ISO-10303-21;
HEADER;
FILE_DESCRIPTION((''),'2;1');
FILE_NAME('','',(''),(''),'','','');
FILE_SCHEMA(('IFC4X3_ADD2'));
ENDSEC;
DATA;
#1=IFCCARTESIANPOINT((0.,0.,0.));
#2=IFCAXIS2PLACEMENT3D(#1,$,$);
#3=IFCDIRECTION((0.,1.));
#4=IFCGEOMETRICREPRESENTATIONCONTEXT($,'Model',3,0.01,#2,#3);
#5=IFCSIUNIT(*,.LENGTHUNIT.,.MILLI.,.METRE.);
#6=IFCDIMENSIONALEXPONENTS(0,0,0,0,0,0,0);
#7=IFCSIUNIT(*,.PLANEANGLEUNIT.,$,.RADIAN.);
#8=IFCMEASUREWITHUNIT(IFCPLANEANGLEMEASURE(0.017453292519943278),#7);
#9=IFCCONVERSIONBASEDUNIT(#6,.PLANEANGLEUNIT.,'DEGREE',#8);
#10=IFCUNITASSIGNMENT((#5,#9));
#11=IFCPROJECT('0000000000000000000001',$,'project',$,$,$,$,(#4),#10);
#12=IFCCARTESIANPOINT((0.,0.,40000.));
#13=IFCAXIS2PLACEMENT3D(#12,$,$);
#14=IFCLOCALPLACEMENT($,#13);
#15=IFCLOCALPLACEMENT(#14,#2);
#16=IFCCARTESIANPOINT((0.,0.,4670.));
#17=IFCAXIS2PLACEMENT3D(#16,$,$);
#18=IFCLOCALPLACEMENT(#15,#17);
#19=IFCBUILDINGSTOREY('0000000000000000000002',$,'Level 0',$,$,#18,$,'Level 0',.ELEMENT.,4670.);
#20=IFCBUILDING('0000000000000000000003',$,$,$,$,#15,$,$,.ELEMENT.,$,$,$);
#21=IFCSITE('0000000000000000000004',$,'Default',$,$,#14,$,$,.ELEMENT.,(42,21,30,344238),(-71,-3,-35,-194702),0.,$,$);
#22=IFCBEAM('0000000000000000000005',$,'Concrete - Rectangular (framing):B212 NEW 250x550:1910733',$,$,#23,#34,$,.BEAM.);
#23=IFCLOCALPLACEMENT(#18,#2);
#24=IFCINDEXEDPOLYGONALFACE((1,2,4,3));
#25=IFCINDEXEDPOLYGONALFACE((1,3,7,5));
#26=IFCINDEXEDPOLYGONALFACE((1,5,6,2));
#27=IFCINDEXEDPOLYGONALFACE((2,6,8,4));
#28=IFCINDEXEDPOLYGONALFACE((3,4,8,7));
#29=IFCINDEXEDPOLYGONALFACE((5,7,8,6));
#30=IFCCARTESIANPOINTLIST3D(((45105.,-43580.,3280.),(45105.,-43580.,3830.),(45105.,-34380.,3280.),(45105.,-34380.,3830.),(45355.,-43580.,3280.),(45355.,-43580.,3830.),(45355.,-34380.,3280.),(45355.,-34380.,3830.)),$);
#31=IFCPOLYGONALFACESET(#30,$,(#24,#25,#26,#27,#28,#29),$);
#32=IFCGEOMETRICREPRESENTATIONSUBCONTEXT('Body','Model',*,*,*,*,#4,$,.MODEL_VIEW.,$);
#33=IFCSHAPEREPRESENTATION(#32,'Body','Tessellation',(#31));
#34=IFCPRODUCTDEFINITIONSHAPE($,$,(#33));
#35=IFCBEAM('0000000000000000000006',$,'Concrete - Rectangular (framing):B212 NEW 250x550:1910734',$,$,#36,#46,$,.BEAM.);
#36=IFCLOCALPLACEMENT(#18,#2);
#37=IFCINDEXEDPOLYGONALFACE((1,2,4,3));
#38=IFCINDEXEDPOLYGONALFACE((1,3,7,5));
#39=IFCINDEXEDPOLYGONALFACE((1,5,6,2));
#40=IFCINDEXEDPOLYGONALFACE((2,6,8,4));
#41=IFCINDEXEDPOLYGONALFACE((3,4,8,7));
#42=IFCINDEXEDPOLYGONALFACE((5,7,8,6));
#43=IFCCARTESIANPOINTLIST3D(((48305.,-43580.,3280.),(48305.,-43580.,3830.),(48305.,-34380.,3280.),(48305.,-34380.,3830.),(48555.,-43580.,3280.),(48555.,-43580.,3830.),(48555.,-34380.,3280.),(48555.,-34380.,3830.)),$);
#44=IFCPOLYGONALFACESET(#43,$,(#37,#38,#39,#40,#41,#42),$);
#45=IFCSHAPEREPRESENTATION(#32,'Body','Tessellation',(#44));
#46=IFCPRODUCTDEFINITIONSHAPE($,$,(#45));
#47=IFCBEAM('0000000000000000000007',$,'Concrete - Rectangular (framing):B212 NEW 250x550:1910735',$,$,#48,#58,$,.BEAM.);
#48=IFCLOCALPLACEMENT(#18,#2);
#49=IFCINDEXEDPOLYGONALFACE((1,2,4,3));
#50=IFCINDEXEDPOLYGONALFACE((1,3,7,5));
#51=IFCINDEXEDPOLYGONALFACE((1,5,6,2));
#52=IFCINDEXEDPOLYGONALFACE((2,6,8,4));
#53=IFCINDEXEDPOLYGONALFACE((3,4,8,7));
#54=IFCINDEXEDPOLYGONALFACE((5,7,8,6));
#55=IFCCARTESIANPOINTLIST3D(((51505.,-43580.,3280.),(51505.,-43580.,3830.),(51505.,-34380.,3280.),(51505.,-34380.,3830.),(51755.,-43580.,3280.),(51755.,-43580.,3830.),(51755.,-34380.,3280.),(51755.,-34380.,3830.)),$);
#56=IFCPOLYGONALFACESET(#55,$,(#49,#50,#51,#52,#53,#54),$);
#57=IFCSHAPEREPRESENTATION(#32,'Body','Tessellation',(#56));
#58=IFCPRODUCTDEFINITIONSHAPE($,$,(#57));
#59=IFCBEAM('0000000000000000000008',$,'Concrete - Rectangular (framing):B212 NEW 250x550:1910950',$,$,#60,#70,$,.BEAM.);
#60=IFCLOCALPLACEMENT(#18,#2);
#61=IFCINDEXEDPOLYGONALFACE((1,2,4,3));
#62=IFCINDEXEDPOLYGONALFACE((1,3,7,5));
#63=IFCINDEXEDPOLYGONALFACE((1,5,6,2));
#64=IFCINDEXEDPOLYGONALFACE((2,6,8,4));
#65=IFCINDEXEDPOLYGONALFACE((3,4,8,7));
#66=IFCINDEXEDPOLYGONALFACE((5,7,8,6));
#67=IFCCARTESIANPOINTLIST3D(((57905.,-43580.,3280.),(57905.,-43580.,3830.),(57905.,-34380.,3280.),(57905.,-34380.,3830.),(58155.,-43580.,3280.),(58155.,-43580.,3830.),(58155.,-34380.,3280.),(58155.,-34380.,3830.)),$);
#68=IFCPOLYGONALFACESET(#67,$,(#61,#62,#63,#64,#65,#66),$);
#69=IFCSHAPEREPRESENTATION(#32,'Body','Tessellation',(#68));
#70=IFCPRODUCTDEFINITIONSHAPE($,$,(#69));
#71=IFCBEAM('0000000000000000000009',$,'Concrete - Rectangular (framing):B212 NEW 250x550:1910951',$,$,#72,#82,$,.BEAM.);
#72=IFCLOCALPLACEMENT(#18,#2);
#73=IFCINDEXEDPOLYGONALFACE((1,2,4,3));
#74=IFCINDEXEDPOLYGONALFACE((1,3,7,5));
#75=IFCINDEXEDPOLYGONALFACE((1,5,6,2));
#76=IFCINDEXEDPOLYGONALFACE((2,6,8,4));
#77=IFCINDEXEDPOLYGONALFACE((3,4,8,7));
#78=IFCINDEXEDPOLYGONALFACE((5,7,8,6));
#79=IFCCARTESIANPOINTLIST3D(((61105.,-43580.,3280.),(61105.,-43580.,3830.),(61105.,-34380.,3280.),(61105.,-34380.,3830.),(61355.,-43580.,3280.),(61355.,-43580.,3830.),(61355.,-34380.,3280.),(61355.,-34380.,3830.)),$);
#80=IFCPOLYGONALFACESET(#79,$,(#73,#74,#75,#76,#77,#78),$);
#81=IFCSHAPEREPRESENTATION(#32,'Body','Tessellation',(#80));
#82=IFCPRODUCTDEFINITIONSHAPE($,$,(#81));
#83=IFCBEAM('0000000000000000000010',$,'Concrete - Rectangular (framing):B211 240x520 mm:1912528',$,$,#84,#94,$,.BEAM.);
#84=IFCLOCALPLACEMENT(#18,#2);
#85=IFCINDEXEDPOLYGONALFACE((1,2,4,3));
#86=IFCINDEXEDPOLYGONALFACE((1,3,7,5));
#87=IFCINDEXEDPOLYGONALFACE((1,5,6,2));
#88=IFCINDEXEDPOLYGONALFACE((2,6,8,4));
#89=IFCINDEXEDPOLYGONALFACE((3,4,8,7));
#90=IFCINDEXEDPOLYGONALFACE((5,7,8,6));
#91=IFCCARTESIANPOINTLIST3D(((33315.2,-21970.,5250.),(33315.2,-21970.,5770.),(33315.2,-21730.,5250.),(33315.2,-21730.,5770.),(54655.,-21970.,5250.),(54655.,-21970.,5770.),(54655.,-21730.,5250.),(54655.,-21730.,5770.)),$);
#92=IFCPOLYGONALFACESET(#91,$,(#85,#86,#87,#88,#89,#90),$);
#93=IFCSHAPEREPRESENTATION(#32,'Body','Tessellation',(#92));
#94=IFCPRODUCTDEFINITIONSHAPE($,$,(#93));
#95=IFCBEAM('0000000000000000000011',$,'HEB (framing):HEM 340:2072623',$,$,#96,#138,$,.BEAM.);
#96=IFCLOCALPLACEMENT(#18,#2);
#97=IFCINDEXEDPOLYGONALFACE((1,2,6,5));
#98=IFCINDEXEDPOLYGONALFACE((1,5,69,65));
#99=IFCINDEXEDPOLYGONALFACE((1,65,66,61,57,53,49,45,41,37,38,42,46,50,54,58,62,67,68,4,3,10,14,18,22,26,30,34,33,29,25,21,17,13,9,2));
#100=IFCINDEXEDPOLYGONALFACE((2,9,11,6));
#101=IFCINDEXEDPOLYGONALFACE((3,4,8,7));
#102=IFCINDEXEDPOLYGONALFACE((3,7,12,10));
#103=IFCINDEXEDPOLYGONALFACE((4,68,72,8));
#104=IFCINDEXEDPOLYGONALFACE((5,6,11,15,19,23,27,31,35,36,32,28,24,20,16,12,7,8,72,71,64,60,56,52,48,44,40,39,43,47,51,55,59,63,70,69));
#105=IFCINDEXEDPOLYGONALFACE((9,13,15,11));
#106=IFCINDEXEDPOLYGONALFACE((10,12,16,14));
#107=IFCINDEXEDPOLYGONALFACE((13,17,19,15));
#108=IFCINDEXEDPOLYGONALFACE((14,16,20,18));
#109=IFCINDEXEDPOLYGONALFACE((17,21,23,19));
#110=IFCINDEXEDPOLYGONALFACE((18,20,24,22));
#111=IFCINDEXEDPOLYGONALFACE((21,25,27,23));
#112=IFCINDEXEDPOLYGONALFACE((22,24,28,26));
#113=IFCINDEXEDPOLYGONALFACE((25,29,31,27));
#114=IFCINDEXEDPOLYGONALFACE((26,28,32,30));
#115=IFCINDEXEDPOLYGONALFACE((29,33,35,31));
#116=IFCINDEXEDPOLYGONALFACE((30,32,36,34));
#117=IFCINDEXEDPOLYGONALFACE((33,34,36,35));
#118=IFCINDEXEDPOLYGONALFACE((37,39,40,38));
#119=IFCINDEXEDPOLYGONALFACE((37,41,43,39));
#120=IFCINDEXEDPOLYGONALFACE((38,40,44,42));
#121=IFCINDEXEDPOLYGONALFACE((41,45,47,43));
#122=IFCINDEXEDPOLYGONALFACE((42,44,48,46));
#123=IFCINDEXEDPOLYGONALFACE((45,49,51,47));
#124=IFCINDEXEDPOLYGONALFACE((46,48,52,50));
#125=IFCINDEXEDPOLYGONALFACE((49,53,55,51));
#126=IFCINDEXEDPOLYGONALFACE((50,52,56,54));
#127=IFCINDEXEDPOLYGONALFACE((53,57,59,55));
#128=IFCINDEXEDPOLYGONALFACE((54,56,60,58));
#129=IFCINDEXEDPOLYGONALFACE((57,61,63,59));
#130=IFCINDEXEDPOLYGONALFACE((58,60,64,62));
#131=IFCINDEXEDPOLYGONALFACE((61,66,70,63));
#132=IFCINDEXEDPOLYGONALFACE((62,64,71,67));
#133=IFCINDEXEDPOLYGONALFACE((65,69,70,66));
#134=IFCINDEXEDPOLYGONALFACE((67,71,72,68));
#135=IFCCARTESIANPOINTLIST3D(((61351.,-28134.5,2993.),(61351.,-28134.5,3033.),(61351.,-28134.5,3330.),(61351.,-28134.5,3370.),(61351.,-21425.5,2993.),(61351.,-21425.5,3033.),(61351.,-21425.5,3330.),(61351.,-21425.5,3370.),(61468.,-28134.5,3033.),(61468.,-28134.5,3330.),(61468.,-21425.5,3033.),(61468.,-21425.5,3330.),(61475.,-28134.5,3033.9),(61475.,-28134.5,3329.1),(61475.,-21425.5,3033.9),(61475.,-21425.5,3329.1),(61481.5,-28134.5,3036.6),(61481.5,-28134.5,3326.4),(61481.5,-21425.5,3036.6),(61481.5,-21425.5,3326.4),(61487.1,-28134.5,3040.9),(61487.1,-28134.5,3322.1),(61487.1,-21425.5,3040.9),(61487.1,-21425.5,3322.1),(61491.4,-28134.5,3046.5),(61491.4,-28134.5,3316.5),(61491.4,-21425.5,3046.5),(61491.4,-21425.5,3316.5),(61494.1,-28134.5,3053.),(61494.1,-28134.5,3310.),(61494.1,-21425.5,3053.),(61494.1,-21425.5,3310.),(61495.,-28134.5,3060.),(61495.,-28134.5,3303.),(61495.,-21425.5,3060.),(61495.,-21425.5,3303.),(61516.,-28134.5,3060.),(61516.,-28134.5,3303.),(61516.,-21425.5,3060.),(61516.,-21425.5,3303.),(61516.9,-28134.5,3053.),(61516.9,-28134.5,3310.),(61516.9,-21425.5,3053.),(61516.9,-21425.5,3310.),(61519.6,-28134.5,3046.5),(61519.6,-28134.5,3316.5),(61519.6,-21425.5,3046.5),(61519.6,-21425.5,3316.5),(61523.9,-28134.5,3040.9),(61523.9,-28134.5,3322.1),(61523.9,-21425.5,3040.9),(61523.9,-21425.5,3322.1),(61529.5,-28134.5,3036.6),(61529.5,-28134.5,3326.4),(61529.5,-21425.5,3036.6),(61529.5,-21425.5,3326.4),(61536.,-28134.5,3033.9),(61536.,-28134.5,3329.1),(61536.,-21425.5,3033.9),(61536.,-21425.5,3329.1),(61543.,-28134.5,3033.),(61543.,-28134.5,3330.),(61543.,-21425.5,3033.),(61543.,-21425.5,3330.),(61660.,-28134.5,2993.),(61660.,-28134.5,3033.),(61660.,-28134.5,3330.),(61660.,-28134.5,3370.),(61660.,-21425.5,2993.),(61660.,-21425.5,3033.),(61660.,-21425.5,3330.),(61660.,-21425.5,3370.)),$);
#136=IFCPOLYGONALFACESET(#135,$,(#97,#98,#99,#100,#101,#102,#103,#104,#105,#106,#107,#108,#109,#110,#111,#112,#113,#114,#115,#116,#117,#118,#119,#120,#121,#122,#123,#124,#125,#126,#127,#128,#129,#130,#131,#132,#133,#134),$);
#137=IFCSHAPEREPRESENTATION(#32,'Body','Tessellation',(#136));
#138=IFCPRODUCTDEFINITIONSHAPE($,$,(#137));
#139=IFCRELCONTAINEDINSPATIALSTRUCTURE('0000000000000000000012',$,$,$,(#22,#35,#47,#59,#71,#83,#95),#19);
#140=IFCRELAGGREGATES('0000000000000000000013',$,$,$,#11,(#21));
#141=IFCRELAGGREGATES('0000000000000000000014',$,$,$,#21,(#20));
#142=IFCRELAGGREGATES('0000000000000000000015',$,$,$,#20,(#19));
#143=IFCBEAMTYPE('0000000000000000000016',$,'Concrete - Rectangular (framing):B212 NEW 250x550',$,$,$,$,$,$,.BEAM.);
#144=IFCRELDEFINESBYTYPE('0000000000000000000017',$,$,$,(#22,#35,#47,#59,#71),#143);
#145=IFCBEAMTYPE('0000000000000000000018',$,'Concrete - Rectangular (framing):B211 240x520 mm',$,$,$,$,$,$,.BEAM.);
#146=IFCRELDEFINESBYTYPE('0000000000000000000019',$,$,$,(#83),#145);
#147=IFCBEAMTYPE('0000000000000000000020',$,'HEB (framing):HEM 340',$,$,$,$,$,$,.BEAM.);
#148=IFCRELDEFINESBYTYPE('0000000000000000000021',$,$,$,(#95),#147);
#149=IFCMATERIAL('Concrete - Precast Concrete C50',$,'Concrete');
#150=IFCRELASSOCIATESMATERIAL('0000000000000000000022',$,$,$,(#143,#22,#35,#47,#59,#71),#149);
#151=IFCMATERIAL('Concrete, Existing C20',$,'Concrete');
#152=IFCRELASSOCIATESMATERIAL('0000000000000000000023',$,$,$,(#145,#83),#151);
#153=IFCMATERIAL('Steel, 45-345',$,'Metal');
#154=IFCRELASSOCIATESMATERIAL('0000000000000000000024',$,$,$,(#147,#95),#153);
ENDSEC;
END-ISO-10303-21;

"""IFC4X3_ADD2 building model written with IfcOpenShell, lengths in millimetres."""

from ifc_helpers import new_model, entity, si_unit, converted_unit, direction, frame, frame_2d, origin, origin_2d_with_axis, place, context, subcontext, project, spatial, polyline, circle_curve, parameter, trimmed, segment, composite_curve, rectangle, outline, extrude, source, transform, mapped, material, material_profile, profile_set, profile_usage, type_object, type_shapes, element, save


model = new_model("IFC4X3_ADD2")

# Units and contexts
model_context = context("Model", 3, precision=0.01, world=origin(), true_north=direction((0.0, 1.0)))
body_context = subcontext(model_context, "Body", "Model", "MODEL_VIEW")
ifc_project = project(units=[si_unit("LENGTHUNIT", "METRE", prefix="MILLI"), converted_unit("PLANEANGLEUNIT", "DEGREE", entity("IfcPlaneAngleMeasure", 0.017453292519943278), si_unit("PLANEANGLEUNIT", "RADIAN"), dimensions=[0, 0, 0, 0, 0, 0, 0])], contexts=[model_context])

# Site, building, storey
site_placement = place(None, frame((0.0, 0.0, 40000.0)))
site = spatial("IfcSite", under=ifc_project, at=site_placement, Name="Default", CompositionType="ELEMENT", RefLatitude=(42, 21, 30, 344238), RefLongitude=(-71, -3, -35, -194702), RefElevation=0.0)
building_placement = place(site_placement, origin())
building = spatial("IfcBuilding", under=site, at=building_placement, CompositionType="ELEMENT")
storey_placement = place(building_placement, frame((0.0, 0.0, 4670.0)))
storey = spatial("IfcBuildingStorey", under=building, at=storey_placement, Name="Level 0", LongName="Level 0", CompositionType="ELEMENT", Elevation=4670.0)

# Shared definitions
ifc_material_1 = material(Name="Steel, 45-345", Category="Metal")

# Beams
ifc_material_profile_1 = material_profile(ifc_material_1, outline(composite_curve([segment(polyline([(-154.5, -148.5), (-154.5, -188.5)]), True, "CONTINUOUS"), segment(polyline([(-154.5, -188.5), (154.5, -188.5)]), True, "CONTINUOUS"), segment(polyline([(154.5, -188.5), (154.5, -148.5)]), True, "CONTINUOUS"), segment(polyline([(154.5, -148.5), (37.5, -148.5)]), True, "CONTINUOUS"), segment(trimmed(circle_curve(frame_2d((37.5, -121.5), x_axis=(1.0, 0.0)), 27.0), [parameter(180.0)], [parameter(270.0)], True, "PARAMETER"), False, "CONTINUOUS"), segment(polyline([(10.5, -121.5), (10.5, 121.5)]), True, "CONTINUOUS"), segment(trimmed(circle_curve(frame_2d((37.5, 121.5), x_axis=(1.0, 0.0)), 27.0), [parameter(90.0)], [parameter(180.0)], True, "PARAMETER"), False, "CONTINUOUS"), segment(polyline([(37.5, 148.5), (154.5, 148.5)]), True, "CONTINUOUS"), segment(polyline([(154.5, 148.5), (154.5, 188.5)]), True, "CONTINUOUS"), segment(polyline([(154.5, 188.5), (-154.5, 188.5)]), True, "CONTINUOUS"), segment(polyline([(-154.5, 188.5), (-154.5, 148.5)]), True, "CONTINUOUS"), segment(polyline([(-154.5, 148.5), (-37.5, 148.5)]), True, "CONTINUOUS"), segment(trimmed(circle_curve(frame_2d((-37.5, 121.5), x_axis=(1.0, 0.0)), 27.0), [parameter(360.0)], [parameter(90.0)], True, "PARAMETER"), False, "CONTINUOUS"), segment(polyline([(-10.5, 121.5), (-10.5, -121.5)]), True, "CONTINUOUS"), segment(trimmed(circle_curve(frame_2d((-37.5, -121.5), x_axis=(1.0, 0.0)), 27.0), [parameter(270.0)], [parameter(0.0)], True, "PARAMETER"), False, "CONTINUOUS"), segment(polyline([(-37.5, -148.5), (-154.5, -148.5)]), True, "CONTINUOUS")], self_intersect=False)), Name="HEM 340")
ifc_profile_set_1 = profile_set([ifc_material_profile_1], Name="HEM 340")
ifc_profile_usage_1 = profile_usage(ifc_profile_set_1, cardinal=8)
ifc_material_2 = material(Name="Concrete - Precast Concrete C50", Category="Concrete")
ifc_material_profile_2 = material_profile(ifc_material_2, rectangle(XDim=9200.0, YDim=250.0, at=origin_2d_with_axis()), Name="B212 NEW 250x550")
ifc_profile_set_2 = profile_set([ifc_material_profile_2], Name="B212 NEW 250x550")
ifc_profile_usage_2 = profile_usage(ifc_profile_set_2, cardinal=8)
beam_type_1 = type_object("IfcBeamType", Name="Concrete - Rectangular (framing):B212 NEW 250x550", PredefinedType="BEAM", material=ifc_profile_set_2)
shared_shape_1 = source(origin(), body_context, "Body", "SweptSolid", [
    extrude(rectangle(XDim=9200.0, YDim=250.0, at=origin_2d_with_axis()), frame((0.0, 0.0, -275.0), z_axis=(0.0, 0.0, 1.0), x_axis=(-1.0, 0.0, 0.0)), (0.0, 0.0, 1.0), 550.0),
])
type_shapes(beam_type_1, [shared_shape_1])
for number, where, z_axis, x_axis, name in (
    (1, (45230.0, -38980.0, 3555.0), (0.0, 0.0, 1.0), (0.0, 1.0, 0.0), "Concrete - Rectangular (framing):B212 NEW 250x550:1910733"),
    (2, (48430.0, -38980.0, 3555.0), (0.0, 0.0, 1.0), (0.0, 1.0, 0.0), "Concrete - Rectangular (framing):B212 NEW 250x550:1910734"),
    (3, (51630.0, -38980.0, 3555.0), (0.0, 0.0, 1.0), (0.0, 1.0, 0.0), "Concrete - Rectangular (framing):B212 NEW 250x550:1910735"),
    (4, (58030.0, -38980.0, 3555.0), (0.0, 0.0, 1.0), (0.0, 1.0, 0.0), "Concrete - Rectangular (framing):B212 NEW 250x550:1910950"),
    (5, (61230.0, -38980.0, 3555.0), (0.0, 0.0, 1.0), (0.0, 1.0, 0.0), "Concrete - Rectangular (framing):B212 NEW 250x550:1910951"),
):
    element("IfcBeam", number, at=place(storey_placement, frame(where, z_axis=z_axis, x_axis=x_axis)), inside=storey, type_object=beam_type_1, material=ifc_profile_usage_2, Name=name, PredefinedType="BEAM", context=body_context, shape_type="MappedRepresentation", body=[
        mapped(shared_shape_1, transform((0.0, 0.0, 0.0), scale=1.0)),
    ])
ifc_material_3 = material(Name="Concrete, Existing C20", Category="Concrete")
ifc_material_profile_3 = material_profile(ifc_material_3, rectangle(XDim=21339.8, YDim=240.0, at=origin_2d_with_axis()), Name="B211 240x520 mm")
ifc_profile_set_3 = profile_set([ifc_material_profile_3], Name="B211 240x520 mm")
ifc_profile_usage_3 = profile_usage(ifc_profile_set_3, cardinal=8)
beam_type_2 = type_object("IfcBeamType", Name="Concrete - Rectangular (framing):B211 240x520 mm", PredefinedType="BEAM", material=ifc_profile_set_3)
shared_shape_2 = source(origin(), body_context, "Body", "SweptSolid", [
    extrude(rectangle(XDim=21339.8, YDim=240.0, at=origin_2d_with_axis()), frame((-60.1, 0.0, -260.0), z_axis=(0.0, 0.0, 1.0), x_axis=(-1.0, 0.0, 0.0)), (0.0, 0.0, 1.0), 520.0),
])
type_shapes(beam_type_2, [shared_shape_2])
beam_1_placement = place(storey_placement, frame((43925.0, -21850.0, 5510.0), z_axis=(0.0, 0.0, 1.0), x_axis=(-1.0, 0.0, 0.0)))
element("IfcBeam", 6, at=beam_1_placement, inside=storey, type_object=beam_type_2, material=ifc_profile_usage_3, Name="Concrete - Rectangular (framing):B211 240x520 mm:1912528", PredefinedType="BEAM", context=body_context, shape_type="MappedRepresentation", body=[
    mapped(shared_shape_2, transform((0.0, 0.0, 0.0), scale=1.0)),
])
beam_type_3 = type_object("IfcBeamType", Name="HEB (framing):HEM 340", PredefinedType="BEAM", material=ifc_profile_set_1)
shared_shape_3 = source(origin(), body_context, "Body", "SweptSolid", [
    extrude(outline(composite_curve([segment(polyline([(-154.5, -148.5), (-154.5, -188.5)]), True, "CONTINUOUS"), segment(polyline([(-154.5, -188.5), (154.5, -188.5)]), True, "CONTINUOUS"), segment(polyline([(154.5, -188.5), (154.5, -148.5)]), True, "CONTINUOUS"), segment(polyline([(154.5, -148.5), (37.5, -148.5)]), True, "CONTINUOUS"), segment(trimmed(circle_curve(frame_2d((37.5, -121.5), x_axis=(1.0, 0.0)), 27.0), [parameter(180.0)], [parameter(270.0)], True, "PARAMETER"), False, "CONTINUOUS"), segment(polyline([(10.5, -121.5), (10.5, 121.5)]), True, "CONTINUOUS"), segment(trimmed(circle_curve(frame_2d((37.5, 121.5), x_axis=(1.0, 0.0)), 27.0), [parameter(90.0)], [parameter(180.0)], True, "PARAMETER"), False, "CONTINUOUS"), segment(polyline([(37.5, 148.5), (154.5, 148.5)]), True, "CONTINUOUS"), segment(polyline([(154.5, 148.5), (154.5, 188.5)]), True, "CONTINUOUS"), segment(polyline([(154.5, 188.5), (-154.5, 188.5)]), True, "CONTINUOUS"), segment(polyline([(-154.5, 188.5), (-154.5, 148.5)]), True, "CONTINUOUS"), segment(polyline([(-154.5, 148.5), (-37.5, 148.5)]), True, "CONTINUOUS"), segment(trimmed(circle_curve(frame_2d((-37.5, 121.5), x_axis=(1.0, 0.0)), 27.0), [parameter(360.0)], [parameter(90.0)], True, "PARAMETER"), False, "CONTINUOUS"), segment(polyline([(-10.5, 121.5), (-10.5, -121.5)]), True, "CONTINUOUS"), segment(trimmed(circle_curve(frame_2d((-37.5, -121.5), x_axis=(1.0, 0.0)), 27.0), [parameter(270.0)], [parameter(0.0)], True, "PARAMETER"), False, "CONTINUOUS"), segment(polyline([(-37.5, -148.5), (-154.5, -148.5)]), True, "CONTINUOUS")], self_intersect=False)), frame((-3354.5, 0.0, 0.0), z_axis=(-1.0, 0.0, 0.0), x_axis=(0.0, -1.0, 0.0)), (0.0, 0.0, -1.0), 6709.0),
])
type_shapes(beam_type_3, [shared_shape_3])
beam_2_placement = place(storey_placement, frame((61505.5, -24780.0, 3181.5), z_axis=(0.0, 0.0, 1.0), x_axis=(0.0, -1.0, 0.0)))
element("IfcBeam", 7, at=beam_2_placement, inside=storey, type_object=beam_type_3, material=ifc_profile_usage_1, Name="HEB (framing):HEM 340:2072623", PredefinedType="BEAM", context=body_context, shape_type="MappedRepresentation", body=[
    mapped(shared_shape_3, transform((0.0, 0.0, 0.0), scale=1.0)),
])

save(model, "model.ifc")
